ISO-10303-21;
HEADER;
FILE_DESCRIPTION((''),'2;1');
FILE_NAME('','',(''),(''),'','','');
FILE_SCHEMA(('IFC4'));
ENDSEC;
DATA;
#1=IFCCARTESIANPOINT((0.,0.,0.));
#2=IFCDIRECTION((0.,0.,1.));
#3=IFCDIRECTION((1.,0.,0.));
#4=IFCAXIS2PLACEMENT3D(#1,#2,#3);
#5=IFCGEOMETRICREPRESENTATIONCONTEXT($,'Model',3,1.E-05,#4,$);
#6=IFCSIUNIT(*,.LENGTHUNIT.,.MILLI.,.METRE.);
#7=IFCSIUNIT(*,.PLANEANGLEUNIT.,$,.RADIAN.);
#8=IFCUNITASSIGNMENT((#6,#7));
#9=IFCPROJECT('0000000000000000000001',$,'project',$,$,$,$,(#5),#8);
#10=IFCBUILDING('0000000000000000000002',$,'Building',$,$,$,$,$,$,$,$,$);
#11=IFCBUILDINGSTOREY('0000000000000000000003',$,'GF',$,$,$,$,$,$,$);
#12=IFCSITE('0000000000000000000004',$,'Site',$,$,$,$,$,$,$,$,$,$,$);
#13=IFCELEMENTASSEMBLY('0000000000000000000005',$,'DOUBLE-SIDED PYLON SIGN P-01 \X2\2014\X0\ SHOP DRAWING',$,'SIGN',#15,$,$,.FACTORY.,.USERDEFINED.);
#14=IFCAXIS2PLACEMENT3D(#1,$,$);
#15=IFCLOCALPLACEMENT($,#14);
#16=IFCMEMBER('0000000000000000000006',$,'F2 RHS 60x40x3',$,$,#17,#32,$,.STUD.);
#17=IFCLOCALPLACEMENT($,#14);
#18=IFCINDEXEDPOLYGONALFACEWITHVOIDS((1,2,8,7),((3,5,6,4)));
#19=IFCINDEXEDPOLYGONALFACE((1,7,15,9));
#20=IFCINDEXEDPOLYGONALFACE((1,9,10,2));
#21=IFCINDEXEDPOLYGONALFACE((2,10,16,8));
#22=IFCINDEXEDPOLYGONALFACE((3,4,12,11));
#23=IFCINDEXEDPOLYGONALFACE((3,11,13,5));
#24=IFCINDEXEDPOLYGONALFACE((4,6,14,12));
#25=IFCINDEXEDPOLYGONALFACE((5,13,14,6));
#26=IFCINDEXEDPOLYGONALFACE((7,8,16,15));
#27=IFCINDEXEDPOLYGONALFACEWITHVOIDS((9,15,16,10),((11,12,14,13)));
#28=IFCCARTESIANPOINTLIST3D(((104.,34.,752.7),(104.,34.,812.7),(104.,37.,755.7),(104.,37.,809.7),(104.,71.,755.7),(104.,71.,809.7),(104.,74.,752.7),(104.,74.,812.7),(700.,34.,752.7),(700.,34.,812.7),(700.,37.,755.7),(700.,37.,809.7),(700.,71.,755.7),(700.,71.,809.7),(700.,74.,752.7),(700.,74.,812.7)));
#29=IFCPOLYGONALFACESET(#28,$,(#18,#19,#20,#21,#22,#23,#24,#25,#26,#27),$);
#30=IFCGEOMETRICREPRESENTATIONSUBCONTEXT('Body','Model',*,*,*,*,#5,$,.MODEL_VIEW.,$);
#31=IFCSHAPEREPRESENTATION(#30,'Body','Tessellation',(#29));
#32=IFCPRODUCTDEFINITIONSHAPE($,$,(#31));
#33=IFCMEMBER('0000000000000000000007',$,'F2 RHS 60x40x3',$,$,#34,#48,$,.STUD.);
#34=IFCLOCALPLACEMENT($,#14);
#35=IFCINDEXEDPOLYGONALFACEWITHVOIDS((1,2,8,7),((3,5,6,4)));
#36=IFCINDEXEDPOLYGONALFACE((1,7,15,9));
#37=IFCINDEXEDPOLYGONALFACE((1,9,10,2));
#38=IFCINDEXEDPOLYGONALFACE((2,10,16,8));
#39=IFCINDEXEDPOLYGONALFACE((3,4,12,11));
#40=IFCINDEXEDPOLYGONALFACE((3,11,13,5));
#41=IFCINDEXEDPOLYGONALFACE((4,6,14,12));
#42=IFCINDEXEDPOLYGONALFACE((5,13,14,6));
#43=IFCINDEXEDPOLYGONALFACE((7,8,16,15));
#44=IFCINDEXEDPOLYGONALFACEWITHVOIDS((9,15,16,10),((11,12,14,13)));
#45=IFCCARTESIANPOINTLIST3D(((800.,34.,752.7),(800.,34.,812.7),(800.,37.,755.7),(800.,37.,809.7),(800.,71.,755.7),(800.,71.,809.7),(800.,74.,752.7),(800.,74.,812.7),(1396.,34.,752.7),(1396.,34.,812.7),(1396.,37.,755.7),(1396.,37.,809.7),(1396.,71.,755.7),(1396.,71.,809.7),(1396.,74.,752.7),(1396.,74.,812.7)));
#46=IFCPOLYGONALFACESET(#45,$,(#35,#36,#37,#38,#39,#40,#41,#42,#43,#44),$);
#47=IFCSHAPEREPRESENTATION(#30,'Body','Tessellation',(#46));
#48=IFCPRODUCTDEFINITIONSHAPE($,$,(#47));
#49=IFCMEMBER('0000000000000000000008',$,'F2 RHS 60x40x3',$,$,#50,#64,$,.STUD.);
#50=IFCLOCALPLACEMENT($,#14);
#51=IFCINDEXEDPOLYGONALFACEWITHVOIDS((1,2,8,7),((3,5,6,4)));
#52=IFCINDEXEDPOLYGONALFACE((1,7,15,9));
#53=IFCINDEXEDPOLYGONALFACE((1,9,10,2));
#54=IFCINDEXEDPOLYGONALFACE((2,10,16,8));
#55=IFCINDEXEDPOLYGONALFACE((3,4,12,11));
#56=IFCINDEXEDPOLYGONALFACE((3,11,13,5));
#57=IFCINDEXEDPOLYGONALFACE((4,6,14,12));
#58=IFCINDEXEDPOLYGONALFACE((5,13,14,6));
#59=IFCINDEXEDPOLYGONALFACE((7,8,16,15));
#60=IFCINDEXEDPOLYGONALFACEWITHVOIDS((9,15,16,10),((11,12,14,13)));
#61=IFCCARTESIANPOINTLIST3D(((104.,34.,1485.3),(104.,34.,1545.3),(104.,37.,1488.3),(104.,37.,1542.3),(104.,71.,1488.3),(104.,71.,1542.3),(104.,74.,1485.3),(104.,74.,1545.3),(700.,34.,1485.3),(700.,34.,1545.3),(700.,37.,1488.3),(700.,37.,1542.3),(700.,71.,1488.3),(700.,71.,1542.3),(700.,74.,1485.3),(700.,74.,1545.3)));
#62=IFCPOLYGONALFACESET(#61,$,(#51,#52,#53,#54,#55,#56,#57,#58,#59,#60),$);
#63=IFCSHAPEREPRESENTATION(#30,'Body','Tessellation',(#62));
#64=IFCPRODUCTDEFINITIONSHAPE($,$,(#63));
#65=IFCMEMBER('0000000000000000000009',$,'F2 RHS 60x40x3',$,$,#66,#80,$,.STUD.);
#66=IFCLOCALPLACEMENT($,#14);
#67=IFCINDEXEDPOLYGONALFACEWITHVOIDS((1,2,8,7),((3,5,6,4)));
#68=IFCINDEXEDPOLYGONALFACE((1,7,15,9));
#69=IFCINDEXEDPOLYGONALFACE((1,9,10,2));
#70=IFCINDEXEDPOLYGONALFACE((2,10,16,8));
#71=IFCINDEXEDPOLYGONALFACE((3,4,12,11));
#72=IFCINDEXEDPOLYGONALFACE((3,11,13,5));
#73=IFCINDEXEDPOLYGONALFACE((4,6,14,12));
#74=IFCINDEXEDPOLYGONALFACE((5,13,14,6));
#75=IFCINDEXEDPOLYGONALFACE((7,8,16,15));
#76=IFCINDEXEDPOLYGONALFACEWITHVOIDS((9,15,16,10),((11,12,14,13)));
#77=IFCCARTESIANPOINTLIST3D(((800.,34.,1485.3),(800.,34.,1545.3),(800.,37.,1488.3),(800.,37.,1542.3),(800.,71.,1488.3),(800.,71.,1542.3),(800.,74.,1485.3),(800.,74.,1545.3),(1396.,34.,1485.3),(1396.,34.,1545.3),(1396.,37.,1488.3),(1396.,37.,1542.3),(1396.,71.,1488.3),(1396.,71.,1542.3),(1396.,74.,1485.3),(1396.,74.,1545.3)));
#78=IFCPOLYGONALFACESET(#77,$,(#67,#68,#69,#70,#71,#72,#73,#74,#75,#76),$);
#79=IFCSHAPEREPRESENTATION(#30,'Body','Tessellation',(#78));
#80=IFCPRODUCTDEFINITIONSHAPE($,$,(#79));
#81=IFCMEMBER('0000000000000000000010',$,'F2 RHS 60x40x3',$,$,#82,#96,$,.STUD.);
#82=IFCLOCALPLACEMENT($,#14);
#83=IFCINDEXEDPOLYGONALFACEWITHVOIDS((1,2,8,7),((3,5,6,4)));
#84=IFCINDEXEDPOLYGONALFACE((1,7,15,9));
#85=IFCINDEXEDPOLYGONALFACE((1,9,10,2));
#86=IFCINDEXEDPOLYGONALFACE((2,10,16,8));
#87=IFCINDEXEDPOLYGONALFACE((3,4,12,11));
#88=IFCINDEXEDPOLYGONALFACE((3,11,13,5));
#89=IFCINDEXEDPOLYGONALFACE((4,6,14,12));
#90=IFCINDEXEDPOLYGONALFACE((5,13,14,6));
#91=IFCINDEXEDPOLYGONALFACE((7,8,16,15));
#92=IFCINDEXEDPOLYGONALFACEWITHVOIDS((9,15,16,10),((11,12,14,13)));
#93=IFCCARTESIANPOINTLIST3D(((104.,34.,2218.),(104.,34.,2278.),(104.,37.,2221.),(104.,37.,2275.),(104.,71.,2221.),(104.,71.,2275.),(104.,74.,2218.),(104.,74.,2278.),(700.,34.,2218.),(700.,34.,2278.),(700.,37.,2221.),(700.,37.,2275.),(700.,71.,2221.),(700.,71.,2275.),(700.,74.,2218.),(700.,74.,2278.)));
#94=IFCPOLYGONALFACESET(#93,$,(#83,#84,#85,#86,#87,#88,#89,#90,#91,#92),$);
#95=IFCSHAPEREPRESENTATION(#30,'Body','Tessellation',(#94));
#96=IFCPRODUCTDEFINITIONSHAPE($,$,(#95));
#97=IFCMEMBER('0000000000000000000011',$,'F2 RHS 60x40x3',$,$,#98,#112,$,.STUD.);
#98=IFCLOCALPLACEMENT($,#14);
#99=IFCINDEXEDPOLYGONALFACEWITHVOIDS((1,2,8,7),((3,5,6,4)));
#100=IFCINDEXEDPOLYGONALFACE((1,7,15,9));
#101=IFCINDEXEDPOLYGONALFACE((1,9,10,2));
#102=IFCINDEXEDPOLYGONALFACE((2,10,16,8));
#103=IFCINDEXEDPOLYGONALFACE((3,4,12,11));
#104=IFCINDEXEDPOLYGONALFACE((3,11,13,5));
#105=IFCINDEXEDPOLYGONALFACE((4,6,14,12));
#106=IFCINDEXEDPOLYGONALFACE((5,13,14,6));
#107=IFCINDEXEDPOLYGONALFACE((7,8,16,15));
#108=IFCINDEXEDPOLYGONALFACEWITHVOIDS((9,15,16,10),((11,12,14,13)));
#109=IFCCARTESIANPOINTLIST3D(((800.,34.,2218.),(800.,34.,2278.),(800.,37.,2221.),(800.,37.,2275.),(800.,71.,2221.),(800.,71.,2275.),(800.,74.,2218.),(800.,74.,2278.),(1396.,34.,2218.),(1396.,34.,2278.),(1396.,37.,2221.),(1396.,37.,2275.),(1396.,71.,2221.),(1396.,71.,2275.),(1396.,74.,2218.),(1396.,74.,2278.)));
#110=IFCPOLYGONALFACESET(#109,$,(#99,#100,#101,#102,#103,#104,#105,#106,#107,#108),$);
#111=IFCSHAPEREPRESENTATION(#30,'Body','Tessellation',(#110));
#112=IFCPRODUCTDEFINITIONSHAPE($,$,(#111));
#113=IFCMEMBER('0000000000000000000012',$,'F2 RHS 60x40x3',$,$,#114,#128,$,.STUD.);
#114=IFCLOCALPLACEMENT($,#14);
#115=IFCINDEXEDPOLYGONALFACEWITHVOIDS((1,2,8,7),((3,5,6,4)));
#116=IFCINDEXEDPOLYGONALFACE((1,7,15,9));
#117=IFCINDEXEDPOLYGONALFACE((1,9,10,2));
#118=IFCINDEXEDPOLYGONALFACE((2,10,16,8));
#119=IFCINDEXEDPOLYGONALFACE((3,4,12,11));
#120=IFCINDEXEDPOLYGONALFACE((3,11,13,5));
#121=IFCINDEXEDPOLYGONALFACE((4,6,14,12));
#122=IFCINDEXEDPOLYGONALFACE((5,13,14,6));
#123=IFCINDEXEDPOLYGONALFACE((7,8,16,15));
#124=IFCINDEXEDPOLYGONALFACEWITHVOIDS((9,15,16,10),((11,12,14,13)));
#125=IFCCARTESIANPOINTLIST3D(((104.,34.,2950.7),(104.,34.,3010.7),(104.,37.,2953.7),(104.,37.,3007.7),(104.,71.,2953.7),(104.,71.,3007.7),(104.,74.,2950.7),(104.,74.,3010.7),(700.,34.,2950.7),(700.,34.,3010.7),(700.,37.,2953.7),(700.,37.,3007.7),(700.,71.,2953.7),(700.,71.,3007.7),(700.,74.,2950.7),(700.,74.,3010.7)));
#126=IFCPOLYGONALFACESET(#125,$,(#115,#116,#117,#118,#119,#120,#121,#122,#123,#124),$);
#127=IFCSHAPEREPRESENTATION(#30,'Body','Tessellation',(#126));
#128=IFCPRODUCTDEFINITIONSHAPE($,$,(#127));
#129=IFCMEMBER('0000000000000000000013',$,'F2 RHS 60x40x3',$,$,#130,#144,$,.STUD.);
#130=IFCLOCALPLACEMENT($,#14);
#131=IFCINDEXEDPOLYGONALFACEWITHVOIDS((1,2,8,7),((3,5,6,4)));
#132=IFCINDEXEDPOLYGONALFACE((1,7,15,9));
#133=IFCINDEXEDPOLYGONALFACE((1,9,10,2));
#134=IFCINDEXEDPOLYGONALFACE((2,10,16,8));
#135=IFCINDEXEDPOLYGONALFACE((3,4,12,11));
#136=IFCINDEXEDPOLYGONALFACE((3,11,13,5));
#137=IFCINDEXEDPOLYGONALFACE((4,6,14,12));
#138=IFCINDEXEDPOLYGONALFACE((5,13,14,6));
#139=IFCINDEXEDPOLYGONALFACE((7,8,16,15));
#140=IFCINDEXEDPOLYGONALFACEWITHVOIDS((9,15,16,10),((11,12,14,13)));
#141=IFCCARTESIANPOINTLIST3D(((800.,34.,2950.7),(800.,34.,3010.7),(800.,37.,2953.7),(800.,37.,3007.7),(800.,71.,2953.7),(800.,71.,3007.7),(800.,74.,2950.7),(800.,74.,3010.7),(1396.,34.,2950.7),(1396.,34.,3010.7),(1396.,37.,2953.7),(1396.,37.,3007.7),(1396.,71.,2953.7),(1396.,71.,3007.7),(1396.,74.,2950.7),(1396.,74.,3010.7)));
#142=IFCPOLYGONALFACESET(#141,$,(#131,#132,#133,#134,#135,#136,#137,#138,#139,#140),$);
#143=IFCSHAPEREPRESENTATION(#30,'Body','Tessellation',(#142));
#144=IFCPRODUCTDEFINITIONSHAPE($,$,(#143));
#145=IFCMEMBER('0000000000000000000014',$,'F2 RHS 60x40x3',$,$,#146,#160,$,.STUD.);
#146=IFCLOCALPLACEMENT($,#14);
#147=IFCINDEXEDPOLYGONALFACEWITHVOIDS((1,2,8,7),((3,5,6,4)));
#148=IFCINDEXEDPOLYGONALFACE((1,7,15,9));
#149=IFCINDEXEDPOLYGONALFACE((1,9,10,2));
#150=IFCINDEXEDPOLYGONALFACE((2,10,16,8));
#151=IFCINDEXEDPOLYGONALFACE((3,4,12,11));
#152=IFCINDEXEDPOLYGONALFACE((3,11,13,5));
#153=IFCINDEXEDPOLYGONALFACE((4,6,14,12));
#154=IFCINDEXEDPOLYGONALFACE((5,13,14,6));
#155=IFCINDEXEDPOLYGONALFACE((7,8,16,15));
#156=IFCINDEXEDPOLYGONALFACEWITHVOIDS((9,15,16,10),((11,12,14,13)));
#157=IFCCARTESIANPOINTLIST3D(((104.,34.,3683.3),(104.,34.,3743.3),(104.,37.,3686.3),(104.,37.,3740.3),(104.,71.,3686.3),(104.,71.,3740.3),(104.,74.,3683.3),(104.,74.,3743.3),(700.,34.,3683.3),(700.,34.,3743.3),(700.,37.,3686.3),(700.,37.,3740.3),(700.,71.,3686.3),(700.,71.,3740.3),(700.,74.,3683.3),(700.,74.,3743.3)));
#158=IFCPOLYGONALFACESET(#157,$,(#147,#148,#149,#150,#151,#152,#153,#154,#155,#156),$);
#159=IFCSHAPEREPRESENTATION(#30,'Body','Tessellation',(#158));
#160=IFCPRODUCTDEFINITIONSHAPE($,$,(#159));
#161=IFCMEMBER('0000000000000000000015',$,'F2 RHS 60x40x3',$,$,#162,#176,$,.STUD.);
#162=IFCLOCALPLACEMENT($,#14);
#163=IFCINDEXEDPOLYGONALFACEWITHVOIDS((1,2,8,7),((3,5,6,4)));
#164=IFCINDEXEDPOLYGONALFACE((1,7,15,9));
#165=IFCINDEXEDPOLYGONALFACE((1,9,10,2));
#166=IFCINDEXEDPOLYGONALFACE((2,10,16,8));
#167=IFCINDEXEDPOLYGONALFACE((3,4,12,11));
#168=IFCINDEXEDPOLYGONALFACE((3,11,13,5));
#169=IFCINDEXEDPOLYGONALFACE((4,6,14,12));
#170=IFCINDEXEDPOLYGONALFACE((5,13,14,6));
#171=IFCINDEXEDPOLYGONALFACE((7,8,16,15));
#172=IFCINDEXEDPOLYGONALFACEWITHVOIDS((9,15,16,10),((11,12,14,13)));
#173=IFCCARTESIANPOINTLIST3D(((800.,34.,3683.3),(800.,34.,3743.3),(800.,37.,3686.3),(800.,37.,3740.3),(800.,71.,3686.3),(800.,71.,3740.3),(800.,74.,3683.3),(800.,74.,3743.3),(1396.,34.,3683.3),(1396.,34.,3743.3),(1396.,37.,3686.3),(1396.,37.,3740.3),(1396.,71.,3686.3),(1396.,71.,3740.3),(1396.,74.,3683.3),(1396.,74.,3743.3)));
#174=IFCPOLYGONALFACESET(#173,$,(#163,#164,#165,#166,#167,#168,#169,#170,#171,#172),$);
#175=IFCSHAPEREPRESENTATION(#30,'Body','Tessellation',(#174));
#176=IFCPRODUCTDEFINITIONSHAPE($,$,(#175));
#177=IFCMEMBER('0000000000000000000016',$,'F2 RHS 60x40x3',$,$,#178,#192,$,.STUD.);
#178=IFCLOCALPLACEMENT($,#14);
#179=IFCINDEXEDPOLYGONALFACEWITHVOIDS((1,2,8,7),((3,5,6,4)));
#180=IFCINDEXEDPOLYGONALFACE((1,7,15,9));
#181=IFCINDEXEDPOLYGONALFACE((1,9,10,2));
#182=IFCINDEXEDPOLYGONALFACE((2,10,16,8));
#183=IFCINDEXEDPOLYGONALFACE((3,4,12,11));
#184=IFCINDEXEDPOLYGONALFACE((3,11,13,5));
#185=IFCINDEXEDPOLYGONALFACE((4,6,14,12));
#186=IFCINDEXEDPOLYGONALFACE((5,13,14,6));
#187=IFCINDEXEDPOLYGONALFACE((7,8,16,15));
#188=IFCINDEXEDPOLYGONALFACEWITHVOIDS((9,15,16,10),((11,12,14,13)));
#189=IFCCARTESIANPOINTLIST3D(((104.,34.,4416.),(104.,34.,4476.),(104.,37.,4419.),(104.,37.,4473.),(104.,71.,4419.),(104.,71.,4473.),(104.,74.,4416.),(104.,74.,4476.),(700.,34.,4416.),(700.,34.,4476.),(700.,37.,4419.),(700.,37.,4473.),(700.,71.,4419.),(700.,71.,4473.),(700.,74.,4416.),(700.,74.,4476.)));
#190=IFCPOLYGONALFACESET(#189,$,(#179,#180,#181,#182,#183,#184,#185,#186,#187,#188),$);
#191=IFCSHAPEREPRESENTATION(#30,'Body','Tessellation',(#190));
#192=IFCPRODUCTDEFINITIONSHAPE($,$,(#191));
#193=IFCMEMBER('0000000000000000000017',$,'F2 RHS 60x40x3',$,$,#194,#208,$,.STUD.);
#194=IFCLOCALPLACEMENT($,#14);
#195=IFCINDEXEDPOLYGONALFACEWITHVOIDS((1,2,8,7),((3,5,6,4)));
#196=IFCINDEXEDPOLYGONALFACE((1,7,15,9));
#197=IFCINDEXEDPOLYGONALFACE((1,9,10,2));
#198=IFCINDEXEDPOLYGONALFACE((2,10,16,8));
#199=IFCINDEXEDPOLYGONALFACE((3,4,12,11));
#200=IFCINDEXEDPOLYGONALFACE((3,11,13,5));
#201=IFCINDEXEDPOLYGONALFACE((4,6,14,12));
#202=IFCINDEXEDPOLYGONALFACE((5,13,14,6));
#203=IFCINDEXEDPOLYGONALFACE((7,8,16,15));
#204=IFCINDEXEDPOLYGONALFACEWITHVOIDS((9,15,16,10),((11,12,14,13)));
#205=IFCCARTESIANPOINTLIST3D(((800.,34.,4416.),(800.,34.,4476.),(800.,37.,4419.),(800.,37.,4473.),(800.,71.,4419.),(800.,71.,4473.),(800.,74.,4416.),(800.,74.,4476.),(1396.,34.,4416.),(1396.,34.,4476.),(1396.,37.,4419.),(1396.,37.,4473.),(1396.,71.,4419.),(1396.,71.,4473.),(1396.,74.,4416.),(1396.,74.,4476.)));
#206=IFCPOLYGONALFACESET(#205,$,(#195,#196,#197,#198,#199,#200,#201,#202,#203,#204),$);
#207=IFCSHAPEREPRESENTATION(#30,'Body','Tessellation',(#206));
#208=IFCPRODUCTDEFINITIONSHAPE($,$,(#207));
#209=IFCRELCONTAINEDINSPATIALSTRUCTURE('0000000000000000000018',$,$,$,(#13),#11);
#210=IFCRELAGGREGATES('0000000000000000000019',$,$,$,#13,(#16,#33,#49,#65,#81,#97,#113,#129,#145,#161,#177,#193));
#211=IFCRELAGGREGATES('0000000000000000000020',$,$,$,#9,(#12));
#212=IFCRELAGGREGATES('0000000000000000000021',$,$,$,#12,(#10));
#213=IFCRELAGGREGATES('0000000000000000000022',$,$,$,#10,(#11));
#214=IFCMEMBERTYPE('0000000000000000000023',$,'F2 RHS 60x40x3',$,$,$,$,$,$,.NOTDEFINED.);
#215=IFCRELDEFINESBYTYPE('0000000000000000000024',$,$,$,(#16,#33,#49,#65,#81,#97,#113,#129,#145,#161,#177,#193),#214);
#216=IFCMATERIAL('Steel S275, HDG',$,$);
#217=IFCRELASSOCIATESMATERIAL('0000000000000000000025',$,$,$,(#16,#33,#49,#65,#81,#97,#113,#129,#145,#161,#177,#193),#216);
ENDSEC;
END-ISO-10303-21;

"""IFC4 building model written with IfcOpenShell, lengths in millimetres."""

from ifc_helpers import new_model, si_unit, frame, origin, origin_with_axes, place, context, subcontext, project, spatial, hollow_rectangle, extrude, material, type_object, element, aggregate, save


model = new_model("IFC4")

# Units and contexts
model_context = context("Model", 3, precision=1e-05, world=origin_with_axes())
body_context = subcontext(model_context, "Body", "Model", "MODEL_VIEW")
ifc_project = project(units=[si_unit("LENGTHUNIT", "METRE", prefix="MILLI"), si_unit("PLANEANGLEUNIT", "RADIAN")], contexts=[model_context])

# Site, building, storey
site = spatial("IfcSite", under=ifc_project, Name="Site")
building = spatial("IfcBuilding", under=site, Name="Building")
storey = spatial("IfcBuildingStorey", under=building, Name="GF")

# Element assembly, members
assembly_placement = place(None, origin_with_axes())
assembly = element("IfcElementAssembly", 1, at=assembly_placement, inside=storey, Name="DOUBLE-SIDED PYLON SIGN P-01 — SHOP DRAWING", ObjectType="SIGN", AssemblyPlace="FACTORY", PredefinedType="USERDEFINED")
ifc_material_1 = material(Name="Steel S275, HDG")
member_type = type_object("IfcMemberType", Name="F2 RHS 60x40x3", PredefinedType="NOTDEFINED")
member_1_placement = place(assembly_placement, frame((104.0, 54.0, 782.7), z_axis=(1.0, 0.0, 0.0), x_axis=(0.0, 0.0, 1.0)))
member_1 = element("IfcMember", 2, at=member_1_placement, type_object=member_type, material=ifc_material_1, Name="F2 RHS 60x40x3", PredefinedType="STUD", context=body_context, shape_type="SweptSolid", body=[
    extrude(hollow_rectangle(XDim=60.0, YDim=40.0, WallThickness=3.0), origin(), (0.0, 0.0, 1.0), 596.0),
])
member_2_placement = place(assembly_placement, frame((800.0, 54.0, 782.7), z_axis=(1.0, 0.0, 0.0), x_axis=(0.0, 0.0, 1.0)))
member_2 = element("IfcMember", 3, at=member_2_placement, type_object=member_type, material=ifc_material_1, Name="F2 RHS 60x40x3", PredefinedType="STUD", context=body_context, shape_type="SweptSolid", body=[
    extrude(hollow_rectangle(XDim=60.0, YDim=40.0, WallThickness=3.0), origin(), (0.0, 0.0, 1.0), 596.0),
])
member_3_placement = place(assembly_placement, frame((104.0, 54.0, 1515.3), z_axis=(1.0, 0.0, 0.0), x_axis=(0.0, 0.0, 1.0)))
member_3 = element("IfcMember", 4, at=member_3_placement, type_object=member_type, material=ifc_material_1, Name="F2 RHS 60x40x3", PredefinedType="STUD", context=body_context, shape_type="SweptSolid", body=[
    extrude(hollow_rectangle(XDim=60.0, YDim=40.0, WallThickness=3.0), origin(), (0.0, 0.0, 1.0), 596.0),
])
member_4_placement = place(assembly_placement, frame((800.0, 54.0, 1515.3), z_axis=(1.0, 0.0, 0.0), x_axis=(0.0, 0.0, 1.0)))
member_4 = element("IfcMember", 5, at=member_4_placement, type_object=member_type, material=ifc_material_1, Name="F2 RHS 60x40x3", PredefinedType="STUD", context=body_context, shape_type="SweptSolid", body=[
    extrude(hollow_rectangle(XDim=60.0, YDim=40.0, WallThickness=3.0), origin(), (0.0, 0.0, 1.0), 596.0),
])
member_5_placement = place(assembly_placement, frame((104.0, 54.0, 2248.0), z_axis=(1.0, 0.0, 0.0), x_axis=(0.0, 0.0, 1.0)))
member_5 = element("IfcMember", 6, at=member_5_placement, type_object=member_type, material=ifc_material_1, Name="F2 RHS 60x40x3", PredefinedType="STUD", context=body_context, shape_type="SweptSolid", body=[
    extrude(hollow_rectangle(XDim=60.0, YDim=40.0, WallThickness=3.0), origin(), (0.0, 0.0, 1.0), 596.0),
])
member_6_placement = place(assembly_placement, frame((800.0, 54.0, 2248.0), z_axis=(1.0, 0.0, 0.0), x_axis=(0.0, 0.0, 1.0)))
member_6 = element("IfcMember", 7, at=member_6_placement, type_object=member_type, material=ifc_material_1, Name="F2 RHS 60x40x3", PredefinedType="STUD", context=body_context, shape_type="SweptSolid", body=[
    extrude(hollow_rectangle(XDim=60.0, YDim=40.0, WallThickness=3.0), origin(), (0.0, 0.0, 1.0), 596.0),
])
member_7_placement = place(assembly_placement, frame((104.0, 54.0, 2980.7), z_axis=(1.0, 0.0, 0.0), x_axis=(0.0, 0.0, 1.0)))
member_7 = element("IfcMember", 8, at=member_7_placement, type_object=member_type, material=ifc_material_1, Name="F2 RHS 60x40x3", PredefinedType="STUD", context=body_context, shape_type="SweptSolid", body=[
    extrude(hollow_rectangle(XDim=60.0, YDim=40.0, WallThickness=3.0), origin(), (0.0, 0.0, 1.0), 596.0),
])
member_8_placement = place(assembly_placement, frame((800.0, 54.0, 2980.7), z_axis=(1.0, 0.0, 0.0), x_axis=(0.0, 0.0, 1.0)))
member_8 = element("IfcMember", 9, at=member_8_placement, type_object=member_type, material=ifc_material_1, Name="F2 RHS 60x40x3", PredefinedType="STUD", context=body_context, shape_type="SweptSolid", body=[
    extrude(hollow_rectangle(XDim=60.0, YDim=40.0, WallThickness=3.0), origin(), (0.0, 0.0, 1.0), 596.0),
])
member_9_placement = place(assembly_placement, frame((104.0, 54.0, 3713.3), z_axis=(1.0, 0.0, 0.0), x_axis=(0.0, 0.0, 1.0)))
member_9 = element("IfcMember", 10, at=member_9_placement, type_object=member_type, material=ifc_material_1, Name="F2 RHS 60x40x3", PredefinedType="STUD", context=body_context, shape_type="SweptSolid", body=[
    extrude(hollow_rectangle(XDim=60.0, YDim=40.0, WallThickness=3.0), origin(), (0.0, 0.0, 1.0), 596.0),
])
member_10_placement = place(assembly_placement, frame((800.0, 54.0, 3713.3), z_axis=(1.0, 0.0, 0.0), x_axis=(0.0, 0.0, 1.0)))
member_10 = element("IfcMember", 11, at=member_10_placement, type_object=member_type, material=ifc_material_1, Name="F2 RHS 60x40x3", PredefinedType="STUD", context=body_context, shape_type="SweptSolid", body=[
    extrude(hollow_rectangle(XDim=60.0, YDim=40.0, WallThickness=3.0), origin(), (0.0, 0.0, 1.0), 596.0),
])
member_11_placement = place(assembly_placement, frame((104.0, 54.0, 4446.0), z_axis=(1.0, 0.0, 0.0), x_axis=(0.0, 0.0, 1.0)))
member_11 = element("IfcMember", 12, at=member_11_placement, type_object=member_type, material=ifc_material_1, Name="F2 RHS 60x40x3", PredefinedType="STUD", context=body_context, shape_type="SweptSolid", body=[
    extrude(hollow_rectangle(XDim=60.0, YDim=40.0, WallThickness=3.0), origin(), (0.0, 0.0, 1.0), 596.0),
])
member_12_placement = place(assembly_placement, frame((800.0, 54.0, 4446.0), z_axis=(1.0, 0.0, 0.0), x_axis=(0.0, 0.0, 1.0)))
member_12 = element("IfcMember", 13, at=member_12_placement, type_object=member_type, material=ifc_material_1, Name="F2 RHS 60x40x3", PredefinedType="STUD", context=body_context, shape_type="SweptSolid", body=[
    extrude(hollow_rectangle(XDim=60.0, YDim=40.0, WallThickness=3.0), origin(), (0.0, 0.0, 1.0), 596.0),
])
aggregate(assembly, [member_1, member_2, member_3, member_4, member_5, member_6, member_7, member_8, member_9, member_10, member_11, member_12])

save(model, "model.ifc")
